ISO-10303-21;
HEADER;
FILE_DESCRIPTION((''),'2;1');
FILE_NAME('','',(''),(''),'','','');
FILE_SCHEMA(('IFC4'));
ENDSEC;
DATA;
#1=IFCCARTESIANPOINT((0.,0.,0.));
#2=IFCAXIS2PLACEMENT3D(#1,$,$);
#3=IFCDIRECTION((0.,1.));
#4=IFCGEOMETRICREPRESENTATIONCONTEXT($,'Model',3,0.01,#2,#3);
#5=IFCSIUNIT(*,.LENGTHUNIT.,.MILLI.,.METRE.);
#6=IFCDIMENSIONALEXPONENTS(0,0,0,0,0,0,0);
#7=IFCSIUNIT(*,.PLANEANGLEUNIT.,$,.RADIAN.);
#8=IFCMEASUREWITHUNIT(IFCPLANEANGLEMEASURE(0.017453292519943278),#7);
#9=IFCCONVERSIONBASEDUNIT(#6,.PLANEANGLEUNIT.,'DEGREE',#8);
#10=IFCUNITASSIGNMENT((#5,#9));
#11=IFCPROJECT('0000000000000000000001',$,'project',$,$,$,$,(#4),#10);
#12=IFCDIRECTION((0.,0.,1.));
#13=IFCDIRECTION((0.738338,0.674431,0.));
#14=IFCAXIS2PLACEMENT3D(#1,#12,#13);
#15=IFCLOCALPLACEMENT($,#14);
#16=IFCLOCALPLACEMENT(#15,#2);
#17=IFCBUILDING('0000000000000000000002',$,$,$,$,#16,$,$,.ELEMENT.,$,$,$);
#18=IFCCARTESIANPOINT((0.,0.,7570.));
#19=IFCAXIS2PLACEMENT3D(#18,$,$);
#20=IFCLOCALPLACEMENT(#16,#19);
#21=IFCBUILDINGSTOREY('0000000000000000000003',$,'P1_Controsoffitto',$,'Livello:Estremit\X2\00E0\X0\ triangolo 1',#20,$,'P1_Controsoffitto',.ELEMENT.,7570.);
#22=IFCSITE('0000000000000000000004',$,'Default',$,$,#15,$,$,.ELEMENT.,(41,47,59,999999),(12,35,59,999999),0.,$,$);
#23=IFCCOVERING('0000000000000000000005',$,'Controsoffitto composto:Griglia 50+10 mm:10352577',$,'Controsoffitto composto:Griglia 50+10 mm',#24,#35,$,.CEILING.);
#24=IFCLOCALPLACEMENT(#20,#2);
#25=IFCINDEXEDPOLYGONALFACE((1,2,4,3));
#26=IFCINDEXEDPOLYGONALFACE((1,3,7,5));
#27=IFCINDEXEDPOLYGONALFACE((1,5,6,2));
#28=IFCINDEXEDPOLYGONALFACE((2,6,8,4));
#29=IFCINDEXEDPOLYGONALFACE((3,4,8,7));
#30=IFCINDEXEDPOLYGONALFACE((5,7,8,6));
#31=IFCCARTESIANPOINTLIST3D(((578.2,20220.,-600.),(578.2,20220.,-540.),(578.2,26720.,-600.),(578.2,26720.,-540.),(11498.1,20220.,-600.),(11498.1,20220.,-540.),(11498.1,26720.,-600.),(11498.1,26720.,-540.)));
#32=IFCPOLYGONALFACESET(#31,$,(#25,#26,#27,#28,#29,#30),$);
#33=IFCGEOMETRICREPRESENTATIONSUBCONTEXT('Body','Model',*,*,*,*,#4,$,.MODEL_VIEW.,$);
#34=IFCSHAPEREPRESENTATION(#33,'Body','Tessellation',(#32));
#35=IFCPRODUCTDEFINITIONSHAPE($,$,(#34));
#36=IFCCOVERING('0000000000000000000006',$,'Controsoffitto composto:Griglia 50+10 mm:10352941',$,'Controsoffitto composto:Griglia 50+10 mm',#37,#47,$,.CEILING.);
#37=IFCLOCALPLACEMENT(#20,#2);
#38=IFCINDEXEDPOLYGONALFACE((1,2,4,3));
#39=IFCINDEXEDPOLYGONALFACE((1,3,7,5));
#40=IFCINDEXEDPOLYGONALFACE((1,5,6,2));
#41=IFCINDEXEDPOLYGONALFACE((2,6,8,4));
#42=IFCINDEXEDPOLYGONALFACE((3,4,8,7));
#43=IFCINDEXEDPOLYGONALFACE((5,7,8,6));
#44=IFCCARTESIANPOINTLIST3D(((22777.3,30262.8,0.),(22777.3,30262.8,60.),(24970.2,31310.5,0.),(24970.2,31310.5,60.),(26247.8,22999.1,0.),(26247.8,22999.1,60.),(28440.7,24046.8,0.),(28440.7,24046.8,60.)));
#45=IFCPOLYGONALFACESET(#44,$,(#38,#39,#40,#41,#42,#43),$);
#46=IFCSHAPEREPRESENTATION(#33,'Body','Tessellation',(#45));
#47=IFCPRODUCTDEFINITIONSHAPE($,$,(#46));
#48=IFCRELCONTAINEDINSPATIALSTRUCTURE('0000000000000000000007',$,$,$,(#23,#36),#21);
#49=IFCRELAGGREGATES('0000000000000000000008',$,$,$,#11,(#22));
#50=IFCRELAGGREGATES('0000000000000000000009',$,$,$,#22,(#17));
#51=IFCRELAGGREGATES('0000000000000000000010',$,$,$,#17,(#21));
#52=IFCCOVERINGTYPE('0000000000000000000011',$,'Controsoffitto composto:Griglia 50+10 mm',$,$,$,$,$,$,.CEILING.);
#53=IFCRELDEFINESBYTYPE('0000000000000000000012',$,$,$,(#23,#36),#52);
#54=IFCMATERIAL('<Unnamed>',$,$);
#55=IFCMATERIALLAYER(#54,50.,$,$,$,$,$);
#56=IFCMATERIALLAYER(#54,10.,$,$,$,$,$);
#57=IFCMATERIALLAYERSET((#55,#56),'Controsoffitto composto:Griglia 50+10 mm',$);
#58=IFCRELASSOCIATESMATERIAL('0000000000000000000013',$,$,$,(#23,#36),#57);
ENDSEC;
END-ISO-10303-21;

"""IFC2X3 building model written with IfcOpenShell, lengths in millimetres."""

from ifc_helpers import new_model, entity, si_unit, converted_unit, direction, frame, frame_2d, origin, place, context, subcontext, project, spatial, rectangle, extrude, material, layer, layer_set, layer_usage, type_object, element, save


model = new_model("IFC2X3")

# Units and contexts
model_context = context("Model", 3, precision=0.01, world=origin(), true_north=direction((0.0, 1.0)))
body_context = subcontext(model_context, "Body", "Model", "MODEL_VIEW")
ifc_project = project(units=[si_unit("LENGTHUNIT", "METRE", prefix="MILLI"), converted_unit("PLANEANGLEUNIT", "DEGREE", entity("IfcPlaneAngleMeasure", 0.017453292519943278), si_unit("PLANEANGLEUNIT", "RADIAN"), dimensions=[0, 0, 0, 0, 0, 0, 0])], contexts=[model_context])

# Site, building, storey
site_placement = place(None, frame((0.0, 0.0, 0.0), z_axis=(0.0, 0.0, 1.0), x_axis=(0.738338, 0.674431, 0.0)))
site = spatial("IfcSite", under=ifc_project, at=site_placement, Name="Default", CompositionType="ELEMENT", RefLatitude=(41, 47, 59, 999999), RefLongitude=(12, 35, 59, 999999), RefElevation=0.0)
building_placement = place(site_placement, origin())
building = spatial("IfcBuilding", under=site, at=building_placement, CompositionType="ELEMENT")
storey_placement = place(building_placement, frame((0.0, 0.0, 7570.0)))
storey = spatial("IfcBuildingStorey", under=building, at=storey_placement, Name="P1_Controsoffitto", ObjectType="Livello:Estremità triangolo 1", LongName="P1_Controsoffitto", CompositionType="ELEMENT", Elevation=7570.0)

# Coverings
ifc_material_1 = material(Name="<Unnamed>")
ifc_layer_1 = layer(ifc_material_1, 50.0)
ifc_layer_2 = layer(ifc_material_1, 10.0)
ifc_layer_set = layer_set([ifc_layer_1, ifc_layer_2], Name="Controsoffitto composto:Griglia 50+10 mm")
covering_type = type_object("IfcCoveringType", Name="Controsoffitto composto:Griglia 50+10 mm", PredefinedType="CEILING")
ifc_layer_usage_1 = layer_usage(ifc_layer_set, "AXIS3", "NEGATIVE", 60.0)
covering_1_placement = place(storey_placement, origin())
element("IfcCovering", 1, at=covering_1_placement, inside=storey, type_object=covering_type, material=ifc_layer_usage_1, Name="Controsoffitto composto:Griglia 50+10 mm:10352577", ObjectType="Controsoffitto composto:Griglia 50+10 mm", PredefinedType="CEILING", context=body_context, shape_type="SweptSolid", body=[
    extrude(rectangle(XDim=10919.8, YDim=6500.0, at=frame_2d((0.0, 0.0), x_axis=(1.0, 0.0))), frame((6038.1, 23470.0, -600.0), z_axis=(0.0, 0.0, 1.0), x_axis=(-1.0, 0.0, 0.0)), (0.0, 0.0, 1.0), 60.0),
])
ifc_layer_usage_2 = layer_usage(ifc_layer_set, "AXIS3", "NEGATIVE", 60.0)
covering_2_placement = place(storey_placement, origin())
element("IfcCovering", 2, at=covering_2_placement, inside=storey, type_object=covering_type, material=ifc_layer_usage_2, Name="Controsoffitto composto:Griglia 50+10 mm:10352941", ObjectType="Controsoffitto composto:Griglia 50+10 mm", PredefinedType="CEILING", context=body_context, shape_type="SweptSolid", body=[
    extrude(rectangle(XDim=2430.3, YDim=8050.2, at=frame_2d((0.0, 0.0), x_axis=(1.0, 0.0))), frame((25609.0, 27154.8, 0.0), z_axis=(0.0, 0.0, 1.0), x_axis=(-0.902302, -0.431105, 0.0)), (0.0, 0.0, 1.0), 60.0),
])

save(model, "model.ifc")
